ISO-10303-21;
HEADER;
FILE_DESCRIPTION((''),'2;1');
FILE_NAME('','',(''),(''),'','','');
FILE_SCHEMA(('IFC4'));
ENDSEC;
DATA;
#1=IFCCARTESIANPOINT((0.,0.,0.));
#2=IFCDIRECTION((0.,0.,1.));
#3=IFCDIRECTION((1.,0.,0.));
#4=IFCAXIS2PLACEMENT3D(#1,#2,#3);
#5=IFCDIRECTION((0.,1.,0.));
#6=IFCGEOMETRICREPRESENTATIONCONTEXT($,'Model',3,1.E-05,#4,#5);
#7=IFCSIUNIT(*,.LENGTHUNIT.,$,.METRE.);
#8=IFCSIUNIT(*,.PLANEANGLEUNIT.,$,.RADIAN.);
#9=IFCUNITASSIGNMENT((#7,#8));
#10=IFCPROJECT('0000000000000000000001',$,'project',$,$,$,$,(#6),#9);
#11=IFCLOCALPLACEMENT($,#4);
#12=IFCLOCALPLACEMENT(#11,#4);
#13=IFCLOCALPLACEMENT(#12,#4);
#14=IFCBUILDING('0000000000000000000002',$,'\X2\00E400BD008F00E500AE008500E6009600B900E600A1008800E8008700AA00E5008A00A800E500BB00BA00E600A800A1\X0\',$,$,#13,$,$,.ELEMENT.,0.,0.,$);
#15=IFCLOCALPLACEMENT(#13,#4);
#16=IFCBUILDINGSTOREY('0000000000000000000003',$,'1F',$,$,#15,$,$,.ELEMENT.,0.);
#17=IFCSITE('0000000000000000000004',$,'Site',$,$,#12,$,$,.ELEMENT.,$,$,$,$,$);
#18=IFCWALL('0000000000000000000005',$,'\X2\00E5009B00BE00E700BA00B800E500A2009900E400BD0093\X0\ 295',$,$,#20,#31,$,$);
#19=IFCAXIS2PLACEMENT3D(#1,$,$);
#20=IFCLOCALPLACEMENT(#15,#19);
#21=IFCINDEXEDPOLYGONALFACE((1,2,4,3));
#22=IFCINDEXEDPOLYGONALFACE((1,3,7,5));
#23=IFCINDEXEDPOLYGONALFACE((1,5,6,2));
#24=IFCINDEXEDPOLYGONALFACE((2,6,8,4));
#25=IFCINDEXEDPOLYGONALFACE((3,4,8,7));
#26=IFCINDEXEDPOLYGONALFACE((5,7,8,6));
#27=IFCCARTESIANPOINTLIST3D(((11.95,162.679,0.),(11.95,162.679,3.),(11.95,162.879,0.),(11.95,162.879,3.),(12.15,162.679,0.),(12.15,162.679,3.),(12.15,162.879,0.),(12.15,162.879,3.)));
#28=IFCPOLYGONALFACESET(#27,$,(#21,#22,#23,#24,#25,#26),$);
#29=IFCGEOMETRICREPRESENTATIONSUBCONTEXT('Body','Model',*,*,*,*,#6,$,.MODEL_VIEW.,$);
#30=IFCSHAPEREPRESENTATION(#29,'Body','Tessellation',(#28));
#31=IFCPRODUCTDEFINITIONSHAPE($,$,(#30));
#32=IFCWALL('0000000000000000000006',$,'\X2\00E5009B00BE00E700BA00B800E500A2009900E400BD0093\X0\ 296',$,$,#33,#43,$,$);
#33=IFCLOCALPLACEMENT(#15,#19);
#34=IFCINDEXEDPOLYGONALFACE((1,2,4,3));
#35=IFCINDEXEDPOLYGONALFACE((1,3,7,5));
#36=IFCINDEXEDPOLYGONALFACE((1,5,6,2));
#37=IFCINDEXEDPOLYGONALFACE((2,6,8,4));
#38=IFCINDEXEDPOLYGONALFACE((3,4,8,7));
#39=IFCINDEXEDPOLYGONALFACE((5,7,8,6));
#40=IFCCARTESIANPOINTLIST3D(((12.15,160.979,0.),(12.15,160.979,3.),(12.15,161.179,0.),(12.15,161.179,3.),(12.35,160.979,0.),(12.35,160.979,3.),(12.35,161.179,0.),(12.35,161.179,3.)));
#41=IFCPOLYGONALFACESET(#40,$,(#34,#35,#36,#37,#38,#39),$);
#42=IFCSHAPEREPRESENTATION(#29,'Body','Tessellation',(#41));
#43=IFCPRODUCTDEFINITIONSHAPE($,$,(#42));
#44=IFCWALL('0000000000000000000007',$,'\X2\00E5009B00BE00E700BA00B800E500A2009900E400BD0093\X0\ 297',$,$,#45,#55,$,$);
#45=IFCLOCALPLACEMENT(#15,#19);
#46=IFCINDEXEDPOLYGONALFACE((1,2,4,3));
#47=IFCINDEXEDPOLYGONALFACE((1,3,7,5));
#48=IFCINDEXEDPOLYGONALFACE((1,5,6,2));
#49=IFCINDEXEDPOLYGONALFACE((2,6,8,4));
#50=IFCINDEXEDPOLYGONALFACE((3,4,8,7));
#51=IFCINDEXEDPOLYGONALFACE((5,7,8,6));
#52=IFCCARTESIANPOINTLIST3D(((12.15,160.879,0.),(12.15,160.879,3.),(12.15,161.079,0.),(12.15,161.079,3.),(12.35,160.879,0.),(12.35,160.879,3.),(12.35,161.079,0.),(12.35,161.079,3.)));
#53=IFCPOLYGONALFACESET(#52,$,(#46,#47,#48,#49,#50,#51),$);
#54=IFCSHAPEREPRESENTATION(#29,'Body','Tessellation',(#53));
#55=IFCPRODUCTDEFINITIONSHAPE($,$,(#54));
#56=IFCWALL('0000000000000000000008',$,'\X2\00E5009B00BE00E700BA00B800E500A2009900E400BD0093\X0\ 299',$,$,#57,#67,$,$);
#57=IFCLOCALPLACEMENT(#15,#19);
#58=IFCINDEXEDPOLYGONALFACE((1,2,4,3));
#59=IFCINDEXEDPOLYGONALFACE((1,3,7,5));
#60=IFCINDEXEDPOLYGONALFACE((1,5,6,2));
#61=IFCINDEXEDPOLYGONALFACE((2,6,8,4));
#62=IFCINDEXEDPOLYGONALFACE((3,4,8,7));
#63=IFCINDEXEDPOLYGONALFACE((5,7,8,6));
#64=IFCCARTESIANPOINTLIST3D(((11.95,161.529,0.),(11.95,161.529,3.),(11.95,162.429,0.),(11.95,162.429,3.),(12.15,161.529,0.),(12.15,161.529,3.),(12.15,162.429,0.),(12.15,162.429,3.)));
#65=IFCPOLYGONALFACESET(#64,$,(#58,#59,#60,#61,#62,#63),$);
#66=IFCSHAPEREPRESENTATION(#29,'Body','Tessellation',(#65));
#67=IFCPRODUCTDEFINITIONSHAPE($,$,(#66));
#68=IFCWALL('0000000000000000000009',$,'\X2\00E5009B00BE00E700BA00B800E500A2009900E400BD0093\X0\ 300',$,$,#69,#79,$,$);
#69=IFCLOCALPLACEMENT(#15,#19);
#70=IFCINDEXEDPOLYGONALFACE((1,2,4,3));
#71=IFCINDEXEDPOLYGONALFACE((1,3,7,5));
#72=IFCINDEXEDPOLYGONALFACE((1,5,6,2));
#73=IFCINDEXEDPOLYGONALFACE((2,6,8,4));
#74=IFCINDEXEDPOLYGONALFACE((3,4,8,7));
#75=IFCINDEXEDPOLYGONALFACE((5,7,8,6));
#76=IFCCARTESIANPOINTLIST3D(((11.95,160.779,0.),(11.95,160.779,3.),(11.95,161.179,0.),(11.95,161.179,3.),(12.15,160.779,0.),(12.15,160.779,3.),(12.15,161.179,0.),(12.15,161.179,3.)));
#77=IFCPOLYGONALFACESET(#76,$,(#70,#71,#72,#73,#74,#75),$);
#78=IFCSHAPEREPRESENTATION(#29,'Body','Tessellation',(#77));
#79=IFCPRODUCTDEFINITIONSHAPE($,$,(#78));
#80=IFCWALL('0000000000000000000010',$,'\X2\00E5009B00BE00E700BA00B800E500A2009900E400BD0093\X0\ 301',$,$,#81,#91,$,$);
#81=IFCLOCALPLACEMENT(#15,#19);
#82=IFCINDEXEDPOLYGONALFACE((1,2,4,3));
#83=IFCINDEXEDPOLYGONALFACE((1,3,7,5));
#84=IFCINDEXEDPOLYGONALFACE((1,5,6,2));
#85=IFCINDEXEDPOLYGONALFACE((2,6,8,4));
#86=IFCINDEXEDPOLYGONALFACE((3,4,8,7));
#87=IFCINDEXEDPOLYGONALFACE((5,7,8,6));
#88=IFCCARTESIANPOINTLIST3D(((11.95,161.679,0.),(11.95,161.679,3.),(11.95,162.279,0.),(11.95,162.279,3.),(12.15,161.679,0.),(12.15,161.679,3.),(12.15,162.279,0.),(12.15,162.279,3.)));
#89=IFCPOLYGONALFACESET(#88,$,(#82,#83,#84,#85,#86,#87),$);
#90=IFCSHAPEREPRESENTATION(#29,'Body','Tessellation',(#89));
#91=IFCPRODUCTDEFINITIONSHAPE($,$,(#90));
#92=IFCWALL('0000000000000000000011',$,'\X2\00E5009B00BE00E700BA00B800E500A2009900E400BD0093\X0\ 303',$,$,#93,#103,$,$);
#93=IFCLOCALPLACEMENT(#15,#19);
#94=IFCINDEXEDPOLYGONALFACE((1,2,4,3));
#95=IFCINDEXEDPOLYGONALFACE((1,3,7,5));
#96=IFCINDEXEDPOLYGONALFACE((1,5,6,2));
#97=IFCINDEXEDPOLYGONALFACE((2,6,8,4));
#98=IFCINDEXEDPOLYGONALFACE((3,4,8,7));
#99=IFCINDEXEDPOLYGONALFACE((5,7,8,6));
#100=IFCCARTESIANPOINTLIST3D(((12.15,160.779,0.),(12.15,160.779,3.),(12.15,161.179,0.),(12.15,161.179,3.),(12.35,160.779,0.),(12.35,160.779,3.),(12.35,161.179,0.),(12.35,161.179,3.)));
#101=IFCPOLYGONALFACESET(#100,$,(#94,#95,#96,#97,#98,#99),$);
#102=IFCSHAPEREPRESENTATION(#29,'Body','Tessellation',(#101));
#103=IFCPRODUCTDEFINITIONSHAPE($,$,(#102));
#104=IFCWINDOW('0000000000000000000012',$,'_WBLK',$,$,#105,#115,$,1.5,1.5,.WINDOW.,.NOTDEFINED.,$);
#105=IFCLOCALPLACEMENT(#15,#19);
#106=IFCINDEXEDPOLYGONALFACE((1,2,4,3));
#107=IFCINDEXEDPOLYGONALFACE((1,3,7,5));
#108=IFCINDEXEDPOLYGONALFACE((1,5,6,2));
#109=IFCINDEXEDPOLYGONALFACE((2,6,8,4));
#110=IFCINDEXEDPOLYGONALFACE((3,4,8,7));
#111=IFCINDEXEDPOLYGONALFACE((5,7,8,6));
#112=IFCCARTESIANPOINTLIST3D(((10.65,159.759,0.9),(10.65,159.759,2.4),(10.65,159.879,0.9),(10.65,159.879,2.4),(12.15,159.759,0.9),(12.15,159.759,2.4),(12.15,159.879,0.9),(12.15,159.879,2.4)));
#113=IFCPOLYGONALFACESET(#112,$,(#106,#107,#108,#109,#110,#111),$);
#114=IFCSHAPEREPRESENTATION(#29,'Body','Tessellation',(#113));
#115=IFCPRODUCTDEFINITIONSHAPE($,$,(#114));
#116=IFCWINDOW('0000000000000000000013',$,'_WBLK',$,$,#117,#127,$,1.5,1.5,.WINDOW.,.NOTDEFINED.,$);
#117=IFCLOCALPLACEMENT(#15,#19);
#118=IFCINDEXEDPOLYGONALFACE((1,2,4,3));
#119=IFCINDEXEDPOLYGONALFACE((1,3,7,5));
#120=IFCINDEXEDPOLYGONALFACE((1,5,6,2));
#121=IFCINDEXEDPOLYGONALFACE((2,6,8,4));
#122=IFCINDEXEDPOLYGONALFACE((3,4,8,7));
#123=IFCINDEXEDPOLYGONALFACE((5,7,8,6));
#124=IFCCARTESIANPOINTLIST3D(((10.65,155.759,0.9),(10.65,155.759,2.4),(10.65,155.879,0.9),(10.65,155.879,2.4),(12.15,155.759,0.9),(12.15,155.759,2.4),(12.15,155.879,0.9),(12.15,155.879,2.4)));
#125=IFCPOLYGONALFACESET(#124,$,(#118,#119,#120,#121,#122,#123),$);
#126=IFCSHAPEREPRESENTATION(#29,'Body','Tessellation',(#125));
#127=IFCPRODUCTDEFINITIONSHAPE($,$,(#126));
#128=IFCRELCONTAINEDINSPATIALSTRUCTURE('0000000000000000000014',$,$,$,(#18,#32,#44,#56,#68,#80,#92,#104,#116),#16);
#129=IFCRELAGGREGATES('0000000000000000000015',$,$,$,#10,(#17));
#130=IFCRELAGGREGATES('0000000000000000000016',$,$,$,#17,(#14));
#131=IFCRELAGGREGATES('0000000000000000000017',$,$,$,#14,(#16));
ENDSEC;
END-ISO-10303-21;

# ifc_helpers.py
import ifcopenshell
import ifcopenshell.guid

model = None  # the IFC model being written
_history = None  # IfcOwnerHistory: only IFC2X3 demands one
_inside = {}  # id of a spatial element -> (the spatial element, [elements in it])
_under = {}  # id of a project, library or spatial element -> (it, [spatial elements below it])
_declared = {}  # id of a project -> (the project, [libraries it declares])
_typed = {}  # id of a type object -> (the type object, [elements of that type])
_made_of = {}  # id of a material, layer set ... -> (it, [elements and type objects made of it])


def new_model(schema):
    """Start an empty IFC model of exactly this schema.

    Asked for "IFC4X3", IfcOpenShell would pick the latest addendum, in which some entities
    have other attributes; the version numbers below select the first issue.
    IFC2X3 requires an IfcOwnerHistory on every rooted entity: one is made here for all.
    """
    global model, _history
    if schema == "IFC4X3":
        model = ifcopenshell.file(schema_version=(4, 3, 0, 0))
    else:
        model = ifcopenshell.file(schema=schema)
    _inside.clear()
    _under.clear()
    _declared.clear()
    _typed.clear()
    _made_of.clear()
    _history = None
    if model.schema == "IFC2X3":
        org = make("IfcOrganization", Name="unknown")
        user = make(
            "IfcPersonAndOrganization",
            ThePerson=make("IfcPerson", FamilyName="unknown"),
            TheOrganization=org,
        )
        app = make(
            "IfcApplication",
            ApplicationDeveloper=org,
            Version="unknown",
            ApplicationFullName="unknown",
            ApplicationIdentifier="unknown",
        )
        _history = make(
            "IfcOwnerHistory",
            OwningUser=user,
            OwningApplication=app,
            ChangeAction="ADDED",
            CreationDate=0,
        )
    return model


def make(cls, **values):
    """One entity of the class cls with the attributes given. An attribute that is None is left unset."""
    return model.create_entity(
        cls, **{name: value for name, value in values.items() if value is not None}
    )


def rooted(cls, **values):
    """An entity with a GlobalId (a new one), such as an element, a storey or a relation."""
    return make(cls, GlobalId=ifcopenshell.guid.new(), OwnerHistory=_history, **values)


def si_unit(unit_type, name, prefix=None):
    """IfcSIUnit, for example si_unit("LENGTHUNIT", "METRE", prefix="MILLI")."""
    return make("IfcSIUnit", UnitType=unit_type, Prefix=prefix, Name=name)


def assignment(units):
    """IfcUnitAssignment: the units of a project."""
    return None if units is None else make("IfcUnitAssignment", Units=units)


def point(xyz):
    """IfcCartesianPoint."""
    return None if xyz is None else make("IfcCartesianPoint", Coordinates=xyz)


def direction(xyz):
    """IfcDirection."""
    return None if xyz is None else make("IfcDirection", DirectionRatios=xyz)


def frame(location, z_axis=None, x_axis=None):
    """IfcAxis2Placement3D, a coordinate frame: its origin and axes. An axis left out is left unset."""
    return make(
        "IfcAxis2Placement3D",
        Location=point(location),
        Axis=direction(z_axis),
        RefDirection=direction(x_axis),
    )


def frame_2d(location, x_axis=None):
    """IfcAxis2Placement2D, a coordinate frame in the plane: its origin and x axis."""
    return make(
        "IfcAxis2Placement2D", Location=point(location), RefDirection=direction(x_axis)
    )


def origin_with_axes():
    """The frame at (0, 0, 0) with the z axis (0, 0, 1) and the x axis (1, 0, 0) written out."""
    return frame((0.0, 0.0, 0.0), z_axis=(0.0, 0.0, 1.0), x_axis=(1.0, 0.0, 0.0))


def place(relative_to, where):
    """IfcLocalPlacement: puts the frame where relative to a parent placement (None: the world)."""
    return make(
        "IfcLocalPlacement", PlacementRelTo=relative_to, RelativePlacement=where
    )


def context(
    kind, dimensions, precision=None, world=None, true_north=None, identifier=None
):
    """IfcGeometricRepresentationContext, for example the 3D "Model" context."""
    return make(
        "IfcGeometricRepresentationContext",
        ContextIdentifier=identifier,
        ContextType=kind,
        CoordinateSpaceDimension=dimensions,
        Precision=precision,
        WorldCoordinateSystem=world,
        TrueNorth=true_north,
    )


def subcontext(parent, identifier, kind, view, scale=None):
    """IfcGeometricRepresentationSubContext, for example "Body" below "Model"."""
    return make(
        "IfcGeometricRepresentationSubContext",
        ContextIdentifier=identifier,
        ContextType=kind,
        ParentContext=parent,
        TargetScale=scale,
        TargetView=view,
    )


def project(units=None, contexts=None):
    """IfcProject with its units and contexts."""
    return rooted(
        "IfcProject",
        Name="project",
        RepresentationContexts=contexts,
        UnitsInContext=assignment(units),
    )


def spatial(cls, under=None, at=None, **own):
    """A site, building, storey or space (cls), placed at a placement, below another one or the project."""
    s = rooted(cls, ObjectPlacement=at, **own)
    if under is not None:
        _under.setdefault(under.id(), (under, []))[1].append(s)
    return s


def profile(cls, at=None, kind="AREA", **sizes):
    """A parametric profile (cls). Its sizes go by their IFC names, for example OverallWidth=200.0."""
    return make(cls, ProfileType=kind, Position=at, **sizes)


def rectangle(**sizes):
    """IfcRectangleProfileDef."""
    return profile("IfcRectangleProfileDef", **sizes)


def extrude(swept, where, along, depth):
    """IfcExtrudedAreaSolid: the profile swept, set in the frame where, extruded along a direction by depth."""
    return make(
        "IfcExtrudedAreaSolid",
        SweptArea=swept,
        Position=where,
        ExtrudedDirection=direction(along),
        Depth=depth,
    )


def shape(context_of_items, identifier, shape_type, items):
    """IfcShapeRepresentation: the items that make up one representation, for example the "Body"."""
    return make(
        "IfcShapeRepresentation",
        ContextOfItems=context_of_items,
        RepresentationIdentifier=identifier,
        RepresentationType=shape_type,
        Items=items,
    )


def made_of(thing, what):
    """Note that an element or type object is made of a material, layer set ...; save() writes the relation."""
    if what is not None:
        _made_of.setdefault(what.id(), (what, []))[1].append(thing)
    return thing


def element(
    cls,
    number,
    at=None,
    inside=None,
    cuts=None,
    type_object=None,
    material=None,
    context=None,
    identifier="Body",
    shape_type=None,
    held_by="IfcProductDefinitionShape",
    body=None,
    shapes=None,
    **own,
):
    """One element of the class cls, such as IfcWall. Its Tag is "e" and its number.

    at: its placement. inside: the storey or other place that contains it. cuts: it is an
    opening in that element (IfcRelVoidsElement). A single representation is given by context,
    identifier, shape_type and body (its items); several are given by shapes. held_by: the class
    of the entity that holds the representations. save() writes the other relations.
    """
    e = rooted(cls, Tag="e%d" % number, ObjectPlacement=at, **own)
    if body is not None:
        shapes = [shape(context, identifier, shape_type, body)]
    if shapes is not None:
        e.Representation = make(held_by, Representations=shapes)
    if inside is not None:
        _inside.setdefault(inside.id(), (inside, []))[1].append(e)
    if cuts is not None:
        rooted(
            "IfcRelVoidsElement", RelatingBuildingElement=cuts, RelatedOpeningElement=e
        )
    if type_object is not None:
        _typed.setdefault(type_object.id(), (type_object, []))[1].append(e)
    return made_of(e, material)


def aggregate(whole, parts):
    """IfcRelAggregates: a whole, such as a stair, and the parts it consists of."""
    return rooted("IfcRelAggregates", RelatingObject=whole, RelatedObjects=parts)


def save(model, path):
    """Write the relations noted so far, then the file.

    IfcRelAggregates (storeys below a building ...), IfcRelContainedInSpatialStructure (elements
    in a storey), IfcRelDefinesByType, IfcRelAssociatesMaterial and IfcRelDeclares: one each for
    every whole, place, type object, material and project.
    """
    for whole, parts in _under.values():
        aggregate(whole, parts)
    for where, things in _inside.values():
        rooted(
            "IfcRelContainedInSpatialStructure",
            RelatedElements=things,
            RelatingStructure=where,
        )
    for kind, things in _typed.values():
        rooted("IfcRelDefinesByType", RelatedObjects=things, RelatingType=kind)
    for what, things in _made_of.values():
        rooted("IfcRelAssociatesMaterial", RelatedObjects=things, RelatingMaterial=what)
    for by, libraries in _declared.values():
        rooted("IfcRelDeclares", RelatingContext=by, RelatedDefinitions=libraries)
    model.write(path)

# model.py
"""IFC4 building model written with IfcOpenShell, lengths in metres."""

from ifc_helpers import new_model, si_unit, direction, frame, frame_2d, origin_with_axes, place, context, subcontext, project, spatial, rectangle, extrude, element, save


model = new_model("IFC4")

# Units and contexts
model_context = context("Model", 3, precision=1e-05, world=origin_with_axes(), true_north=direction((0.0, 1.0, 0.0)))
body_context = subcontext(model_context, "Body", "Model", "MODEL_VIEW")
ifc_project = project(units=[si_unit("LENGTHUNIT", "METRE"), si_unit("PLANEANGLEUNIT", "RADIAN")], contexts=[model_context])

# Site, building, storey
placement = place(None, origin_with_axes())
site_placement = place(placement, origin_with_axes())
site = spatial("IfcSite", under=ifc_project, at=site_placement, Name="Site", CompositionType="ELEMENT")
building_placement = place(site_placement, origin_with_axes())
building = spatial("IfcBuilding", under=site, at=building_placement, Name="ä½\u008få®\u0085æ\u0096¹æ¡\u0088è\u0087ªå\u008a¨å»ºæ¨¡", CompositionType="ELEMENT", ElevationOfRefHeight=0.0, ElevationOfTerrain=0.0)
storey_placement = place(building_placement, origin_with_axes())
storey = spatial("IfcBuildingStorey", under=building, at=storey_placement, Name="1F", CompositionType="ELEMENT", Elevation=0.0)

# Walls
for number, where, z_axis, x_axis, name in (
    (1, (12.05, 162.779, 0.0), (0.0, 0.0, 1.0), (1.0, 0.0, 0.0), "å\u009b¾çº¸å¢\u0099ä½\u0093 295"),
    (2, (12.25, 161.079, 0.0), (0.0, 0.0, 1.0), (-1.0, 0.0, 0.0), "å\u009b¾çº¸å¢\u0099ä½\u0093 296"),
    (3, (12.25, 160.979, 0.0), (0.0, 0.0, 1.0), (-1.0, 0.0, 0.0), "å\u009b¾çº¸å¢\u0099ä½\u0093 297"),
):
    element("IfcWall", number, at=place(storey_placement, frame(where, z_axis=z_axis, x_axis=x_axis)), inside=storey, Name=name, context=body_context, shape_type="SweptSolid", body=[
        extrude(rectangle(XDim=0.2, YDim=0.2, at=frame_2d((0.0, 0.0), x_axis=(1.0, 0.0, 0.0))), frame((0.0, 0.0, 0.0), z_axis=(0.0, 0.0, 1.0)), (0.0, 0.0, 1.0), 3.0),
    ])
wall_1_placement = place(storey_placement, frame((12.05, 161.979, 0.0), z_axis=(0.0, 0.0, 1.0), x_axis=(0.0, 1.0, 0.0)))
element("IfcWall", 4, at=wall_1_placement, inside=storey, Name="å\u009b¾çº¸å¢\u0099ä½\u0093 299", context=body_context, shape_type="SweptSolid", body=[
    extrude(rectangle(XDim=0.9, YDim=0.2, at=frame_2d((0.0, 0.0), x_axis=(1.0, 0.0, 0.0))), frame((0.0, 0.0, 0.0), z_axis=(0.0, 0.0, 1.0)), (0.0, 0.0, 1.0), 3.0),
])
wall_2_placement = place(storey_placement, frame((12.05, 160.979, 0.0), z_axis=(0.0, 0.0, 1.0), x_axis=(0.0, 1.0, 0.0)))
element("IfcWall", 5, at=wall_2_placement, inside=storey, Name="å\u009b¾çº¸å¢\u0099ä½\u0093 300", context=body_context, shape_type="SweptSolid", body=[
    extrude(rectangle(XDim=0.4, YDim=0.2, at=frame_2d((0.0, 0.0), x_axis=(1.0, 0.0, 0.0))), frame((0.0, 0.0, 0.0), z_axis=(0.0, 0.0, 1.0)), (0.0, 0.0, 1.0), 3.0),
])
wall_3_placement = place(storey_placement, frame((12.05, 161.979, 0.0), z_axis=(0.0, 0.0, 1.0), x_axis=(0.0, -1.0, 0.0)))
element("IfcWall", 6, at=wall_3_placement, inside=storey, Name="å\u009b¾çº¸å¢\u0099ä½\u0093 301", context=body_context, shape_type="SweptSolid", body=[
    extrude(rectangle(XDim=0.6, YDim=0.2, at=frame_2d((0.0, 0.0), x_axis=(1.0, 0.0, 0.0))), frame((0.0, 0.0, 0.0), z_axis=(0.0, 0.0, 1.0)), (0.0, 0.0, 1.0), 3.0),
])
wall_4_placement = place(storey_placement, frame((12.25, 160.979, 0.0), z_axis=(0.0, 0.0, 1.0), x_axis=(0.0, 1.0, 0.0)))
element("IfcWall", 7, at=wall_4_placement, inside=storey, Name="å\u009b¾çº¸å¢\u0099ä½\u0093 303", context=body_context, shape_type="SweptSolid", body=[
    extrude(rectangle(XDim=0.4, YDim=0.2, at=frame_2d((0.0, 0.0), x_axis=(1.0, 0.0, 0.0))), frame((0.0, 0.0, 0.0), z_axis=(0.0, 0.0, 1.0)), (0.0, 0.0, 1.0), 3.0),
])

# Windows
for number, where, z_axis, x_axis, name in (
    (8, (11.4, 159.819, 0.9), (0.0, 0.0, 1.0), (1.0, 0.0, 0.0), "_WBLK"),
    (9, (11.4, 155.819, 0.9), (0.0, 0.0, 1.0), (1.0, 0.0, 0.0), "_WBLK"),
):
    element("IfcWindow", number, at=place(storey_placement, frame(where, z_axis=z_axis, x_axis=x_axis)), inside=storey, Name=name, OverallHeight=1.5, OverallWidth=1.5, PartitioningType="NOTDEFINED", PredefinedType="WINDOW", context=body_context, shape_type="SweptSolid", body=[
        extrude(rectangle(XDim=1.5, YDim=0.12, at=frame_2d((0.0, 0.0), x_axis=(1.0, 0.0, 0.0))), frame((0.0, 0.0, 0.0), z_axis=(0.0, 0.0, 1.0)), (0.0, 0.0, 1.0), 1.5),
    ])

save(model, "model.ifc")
